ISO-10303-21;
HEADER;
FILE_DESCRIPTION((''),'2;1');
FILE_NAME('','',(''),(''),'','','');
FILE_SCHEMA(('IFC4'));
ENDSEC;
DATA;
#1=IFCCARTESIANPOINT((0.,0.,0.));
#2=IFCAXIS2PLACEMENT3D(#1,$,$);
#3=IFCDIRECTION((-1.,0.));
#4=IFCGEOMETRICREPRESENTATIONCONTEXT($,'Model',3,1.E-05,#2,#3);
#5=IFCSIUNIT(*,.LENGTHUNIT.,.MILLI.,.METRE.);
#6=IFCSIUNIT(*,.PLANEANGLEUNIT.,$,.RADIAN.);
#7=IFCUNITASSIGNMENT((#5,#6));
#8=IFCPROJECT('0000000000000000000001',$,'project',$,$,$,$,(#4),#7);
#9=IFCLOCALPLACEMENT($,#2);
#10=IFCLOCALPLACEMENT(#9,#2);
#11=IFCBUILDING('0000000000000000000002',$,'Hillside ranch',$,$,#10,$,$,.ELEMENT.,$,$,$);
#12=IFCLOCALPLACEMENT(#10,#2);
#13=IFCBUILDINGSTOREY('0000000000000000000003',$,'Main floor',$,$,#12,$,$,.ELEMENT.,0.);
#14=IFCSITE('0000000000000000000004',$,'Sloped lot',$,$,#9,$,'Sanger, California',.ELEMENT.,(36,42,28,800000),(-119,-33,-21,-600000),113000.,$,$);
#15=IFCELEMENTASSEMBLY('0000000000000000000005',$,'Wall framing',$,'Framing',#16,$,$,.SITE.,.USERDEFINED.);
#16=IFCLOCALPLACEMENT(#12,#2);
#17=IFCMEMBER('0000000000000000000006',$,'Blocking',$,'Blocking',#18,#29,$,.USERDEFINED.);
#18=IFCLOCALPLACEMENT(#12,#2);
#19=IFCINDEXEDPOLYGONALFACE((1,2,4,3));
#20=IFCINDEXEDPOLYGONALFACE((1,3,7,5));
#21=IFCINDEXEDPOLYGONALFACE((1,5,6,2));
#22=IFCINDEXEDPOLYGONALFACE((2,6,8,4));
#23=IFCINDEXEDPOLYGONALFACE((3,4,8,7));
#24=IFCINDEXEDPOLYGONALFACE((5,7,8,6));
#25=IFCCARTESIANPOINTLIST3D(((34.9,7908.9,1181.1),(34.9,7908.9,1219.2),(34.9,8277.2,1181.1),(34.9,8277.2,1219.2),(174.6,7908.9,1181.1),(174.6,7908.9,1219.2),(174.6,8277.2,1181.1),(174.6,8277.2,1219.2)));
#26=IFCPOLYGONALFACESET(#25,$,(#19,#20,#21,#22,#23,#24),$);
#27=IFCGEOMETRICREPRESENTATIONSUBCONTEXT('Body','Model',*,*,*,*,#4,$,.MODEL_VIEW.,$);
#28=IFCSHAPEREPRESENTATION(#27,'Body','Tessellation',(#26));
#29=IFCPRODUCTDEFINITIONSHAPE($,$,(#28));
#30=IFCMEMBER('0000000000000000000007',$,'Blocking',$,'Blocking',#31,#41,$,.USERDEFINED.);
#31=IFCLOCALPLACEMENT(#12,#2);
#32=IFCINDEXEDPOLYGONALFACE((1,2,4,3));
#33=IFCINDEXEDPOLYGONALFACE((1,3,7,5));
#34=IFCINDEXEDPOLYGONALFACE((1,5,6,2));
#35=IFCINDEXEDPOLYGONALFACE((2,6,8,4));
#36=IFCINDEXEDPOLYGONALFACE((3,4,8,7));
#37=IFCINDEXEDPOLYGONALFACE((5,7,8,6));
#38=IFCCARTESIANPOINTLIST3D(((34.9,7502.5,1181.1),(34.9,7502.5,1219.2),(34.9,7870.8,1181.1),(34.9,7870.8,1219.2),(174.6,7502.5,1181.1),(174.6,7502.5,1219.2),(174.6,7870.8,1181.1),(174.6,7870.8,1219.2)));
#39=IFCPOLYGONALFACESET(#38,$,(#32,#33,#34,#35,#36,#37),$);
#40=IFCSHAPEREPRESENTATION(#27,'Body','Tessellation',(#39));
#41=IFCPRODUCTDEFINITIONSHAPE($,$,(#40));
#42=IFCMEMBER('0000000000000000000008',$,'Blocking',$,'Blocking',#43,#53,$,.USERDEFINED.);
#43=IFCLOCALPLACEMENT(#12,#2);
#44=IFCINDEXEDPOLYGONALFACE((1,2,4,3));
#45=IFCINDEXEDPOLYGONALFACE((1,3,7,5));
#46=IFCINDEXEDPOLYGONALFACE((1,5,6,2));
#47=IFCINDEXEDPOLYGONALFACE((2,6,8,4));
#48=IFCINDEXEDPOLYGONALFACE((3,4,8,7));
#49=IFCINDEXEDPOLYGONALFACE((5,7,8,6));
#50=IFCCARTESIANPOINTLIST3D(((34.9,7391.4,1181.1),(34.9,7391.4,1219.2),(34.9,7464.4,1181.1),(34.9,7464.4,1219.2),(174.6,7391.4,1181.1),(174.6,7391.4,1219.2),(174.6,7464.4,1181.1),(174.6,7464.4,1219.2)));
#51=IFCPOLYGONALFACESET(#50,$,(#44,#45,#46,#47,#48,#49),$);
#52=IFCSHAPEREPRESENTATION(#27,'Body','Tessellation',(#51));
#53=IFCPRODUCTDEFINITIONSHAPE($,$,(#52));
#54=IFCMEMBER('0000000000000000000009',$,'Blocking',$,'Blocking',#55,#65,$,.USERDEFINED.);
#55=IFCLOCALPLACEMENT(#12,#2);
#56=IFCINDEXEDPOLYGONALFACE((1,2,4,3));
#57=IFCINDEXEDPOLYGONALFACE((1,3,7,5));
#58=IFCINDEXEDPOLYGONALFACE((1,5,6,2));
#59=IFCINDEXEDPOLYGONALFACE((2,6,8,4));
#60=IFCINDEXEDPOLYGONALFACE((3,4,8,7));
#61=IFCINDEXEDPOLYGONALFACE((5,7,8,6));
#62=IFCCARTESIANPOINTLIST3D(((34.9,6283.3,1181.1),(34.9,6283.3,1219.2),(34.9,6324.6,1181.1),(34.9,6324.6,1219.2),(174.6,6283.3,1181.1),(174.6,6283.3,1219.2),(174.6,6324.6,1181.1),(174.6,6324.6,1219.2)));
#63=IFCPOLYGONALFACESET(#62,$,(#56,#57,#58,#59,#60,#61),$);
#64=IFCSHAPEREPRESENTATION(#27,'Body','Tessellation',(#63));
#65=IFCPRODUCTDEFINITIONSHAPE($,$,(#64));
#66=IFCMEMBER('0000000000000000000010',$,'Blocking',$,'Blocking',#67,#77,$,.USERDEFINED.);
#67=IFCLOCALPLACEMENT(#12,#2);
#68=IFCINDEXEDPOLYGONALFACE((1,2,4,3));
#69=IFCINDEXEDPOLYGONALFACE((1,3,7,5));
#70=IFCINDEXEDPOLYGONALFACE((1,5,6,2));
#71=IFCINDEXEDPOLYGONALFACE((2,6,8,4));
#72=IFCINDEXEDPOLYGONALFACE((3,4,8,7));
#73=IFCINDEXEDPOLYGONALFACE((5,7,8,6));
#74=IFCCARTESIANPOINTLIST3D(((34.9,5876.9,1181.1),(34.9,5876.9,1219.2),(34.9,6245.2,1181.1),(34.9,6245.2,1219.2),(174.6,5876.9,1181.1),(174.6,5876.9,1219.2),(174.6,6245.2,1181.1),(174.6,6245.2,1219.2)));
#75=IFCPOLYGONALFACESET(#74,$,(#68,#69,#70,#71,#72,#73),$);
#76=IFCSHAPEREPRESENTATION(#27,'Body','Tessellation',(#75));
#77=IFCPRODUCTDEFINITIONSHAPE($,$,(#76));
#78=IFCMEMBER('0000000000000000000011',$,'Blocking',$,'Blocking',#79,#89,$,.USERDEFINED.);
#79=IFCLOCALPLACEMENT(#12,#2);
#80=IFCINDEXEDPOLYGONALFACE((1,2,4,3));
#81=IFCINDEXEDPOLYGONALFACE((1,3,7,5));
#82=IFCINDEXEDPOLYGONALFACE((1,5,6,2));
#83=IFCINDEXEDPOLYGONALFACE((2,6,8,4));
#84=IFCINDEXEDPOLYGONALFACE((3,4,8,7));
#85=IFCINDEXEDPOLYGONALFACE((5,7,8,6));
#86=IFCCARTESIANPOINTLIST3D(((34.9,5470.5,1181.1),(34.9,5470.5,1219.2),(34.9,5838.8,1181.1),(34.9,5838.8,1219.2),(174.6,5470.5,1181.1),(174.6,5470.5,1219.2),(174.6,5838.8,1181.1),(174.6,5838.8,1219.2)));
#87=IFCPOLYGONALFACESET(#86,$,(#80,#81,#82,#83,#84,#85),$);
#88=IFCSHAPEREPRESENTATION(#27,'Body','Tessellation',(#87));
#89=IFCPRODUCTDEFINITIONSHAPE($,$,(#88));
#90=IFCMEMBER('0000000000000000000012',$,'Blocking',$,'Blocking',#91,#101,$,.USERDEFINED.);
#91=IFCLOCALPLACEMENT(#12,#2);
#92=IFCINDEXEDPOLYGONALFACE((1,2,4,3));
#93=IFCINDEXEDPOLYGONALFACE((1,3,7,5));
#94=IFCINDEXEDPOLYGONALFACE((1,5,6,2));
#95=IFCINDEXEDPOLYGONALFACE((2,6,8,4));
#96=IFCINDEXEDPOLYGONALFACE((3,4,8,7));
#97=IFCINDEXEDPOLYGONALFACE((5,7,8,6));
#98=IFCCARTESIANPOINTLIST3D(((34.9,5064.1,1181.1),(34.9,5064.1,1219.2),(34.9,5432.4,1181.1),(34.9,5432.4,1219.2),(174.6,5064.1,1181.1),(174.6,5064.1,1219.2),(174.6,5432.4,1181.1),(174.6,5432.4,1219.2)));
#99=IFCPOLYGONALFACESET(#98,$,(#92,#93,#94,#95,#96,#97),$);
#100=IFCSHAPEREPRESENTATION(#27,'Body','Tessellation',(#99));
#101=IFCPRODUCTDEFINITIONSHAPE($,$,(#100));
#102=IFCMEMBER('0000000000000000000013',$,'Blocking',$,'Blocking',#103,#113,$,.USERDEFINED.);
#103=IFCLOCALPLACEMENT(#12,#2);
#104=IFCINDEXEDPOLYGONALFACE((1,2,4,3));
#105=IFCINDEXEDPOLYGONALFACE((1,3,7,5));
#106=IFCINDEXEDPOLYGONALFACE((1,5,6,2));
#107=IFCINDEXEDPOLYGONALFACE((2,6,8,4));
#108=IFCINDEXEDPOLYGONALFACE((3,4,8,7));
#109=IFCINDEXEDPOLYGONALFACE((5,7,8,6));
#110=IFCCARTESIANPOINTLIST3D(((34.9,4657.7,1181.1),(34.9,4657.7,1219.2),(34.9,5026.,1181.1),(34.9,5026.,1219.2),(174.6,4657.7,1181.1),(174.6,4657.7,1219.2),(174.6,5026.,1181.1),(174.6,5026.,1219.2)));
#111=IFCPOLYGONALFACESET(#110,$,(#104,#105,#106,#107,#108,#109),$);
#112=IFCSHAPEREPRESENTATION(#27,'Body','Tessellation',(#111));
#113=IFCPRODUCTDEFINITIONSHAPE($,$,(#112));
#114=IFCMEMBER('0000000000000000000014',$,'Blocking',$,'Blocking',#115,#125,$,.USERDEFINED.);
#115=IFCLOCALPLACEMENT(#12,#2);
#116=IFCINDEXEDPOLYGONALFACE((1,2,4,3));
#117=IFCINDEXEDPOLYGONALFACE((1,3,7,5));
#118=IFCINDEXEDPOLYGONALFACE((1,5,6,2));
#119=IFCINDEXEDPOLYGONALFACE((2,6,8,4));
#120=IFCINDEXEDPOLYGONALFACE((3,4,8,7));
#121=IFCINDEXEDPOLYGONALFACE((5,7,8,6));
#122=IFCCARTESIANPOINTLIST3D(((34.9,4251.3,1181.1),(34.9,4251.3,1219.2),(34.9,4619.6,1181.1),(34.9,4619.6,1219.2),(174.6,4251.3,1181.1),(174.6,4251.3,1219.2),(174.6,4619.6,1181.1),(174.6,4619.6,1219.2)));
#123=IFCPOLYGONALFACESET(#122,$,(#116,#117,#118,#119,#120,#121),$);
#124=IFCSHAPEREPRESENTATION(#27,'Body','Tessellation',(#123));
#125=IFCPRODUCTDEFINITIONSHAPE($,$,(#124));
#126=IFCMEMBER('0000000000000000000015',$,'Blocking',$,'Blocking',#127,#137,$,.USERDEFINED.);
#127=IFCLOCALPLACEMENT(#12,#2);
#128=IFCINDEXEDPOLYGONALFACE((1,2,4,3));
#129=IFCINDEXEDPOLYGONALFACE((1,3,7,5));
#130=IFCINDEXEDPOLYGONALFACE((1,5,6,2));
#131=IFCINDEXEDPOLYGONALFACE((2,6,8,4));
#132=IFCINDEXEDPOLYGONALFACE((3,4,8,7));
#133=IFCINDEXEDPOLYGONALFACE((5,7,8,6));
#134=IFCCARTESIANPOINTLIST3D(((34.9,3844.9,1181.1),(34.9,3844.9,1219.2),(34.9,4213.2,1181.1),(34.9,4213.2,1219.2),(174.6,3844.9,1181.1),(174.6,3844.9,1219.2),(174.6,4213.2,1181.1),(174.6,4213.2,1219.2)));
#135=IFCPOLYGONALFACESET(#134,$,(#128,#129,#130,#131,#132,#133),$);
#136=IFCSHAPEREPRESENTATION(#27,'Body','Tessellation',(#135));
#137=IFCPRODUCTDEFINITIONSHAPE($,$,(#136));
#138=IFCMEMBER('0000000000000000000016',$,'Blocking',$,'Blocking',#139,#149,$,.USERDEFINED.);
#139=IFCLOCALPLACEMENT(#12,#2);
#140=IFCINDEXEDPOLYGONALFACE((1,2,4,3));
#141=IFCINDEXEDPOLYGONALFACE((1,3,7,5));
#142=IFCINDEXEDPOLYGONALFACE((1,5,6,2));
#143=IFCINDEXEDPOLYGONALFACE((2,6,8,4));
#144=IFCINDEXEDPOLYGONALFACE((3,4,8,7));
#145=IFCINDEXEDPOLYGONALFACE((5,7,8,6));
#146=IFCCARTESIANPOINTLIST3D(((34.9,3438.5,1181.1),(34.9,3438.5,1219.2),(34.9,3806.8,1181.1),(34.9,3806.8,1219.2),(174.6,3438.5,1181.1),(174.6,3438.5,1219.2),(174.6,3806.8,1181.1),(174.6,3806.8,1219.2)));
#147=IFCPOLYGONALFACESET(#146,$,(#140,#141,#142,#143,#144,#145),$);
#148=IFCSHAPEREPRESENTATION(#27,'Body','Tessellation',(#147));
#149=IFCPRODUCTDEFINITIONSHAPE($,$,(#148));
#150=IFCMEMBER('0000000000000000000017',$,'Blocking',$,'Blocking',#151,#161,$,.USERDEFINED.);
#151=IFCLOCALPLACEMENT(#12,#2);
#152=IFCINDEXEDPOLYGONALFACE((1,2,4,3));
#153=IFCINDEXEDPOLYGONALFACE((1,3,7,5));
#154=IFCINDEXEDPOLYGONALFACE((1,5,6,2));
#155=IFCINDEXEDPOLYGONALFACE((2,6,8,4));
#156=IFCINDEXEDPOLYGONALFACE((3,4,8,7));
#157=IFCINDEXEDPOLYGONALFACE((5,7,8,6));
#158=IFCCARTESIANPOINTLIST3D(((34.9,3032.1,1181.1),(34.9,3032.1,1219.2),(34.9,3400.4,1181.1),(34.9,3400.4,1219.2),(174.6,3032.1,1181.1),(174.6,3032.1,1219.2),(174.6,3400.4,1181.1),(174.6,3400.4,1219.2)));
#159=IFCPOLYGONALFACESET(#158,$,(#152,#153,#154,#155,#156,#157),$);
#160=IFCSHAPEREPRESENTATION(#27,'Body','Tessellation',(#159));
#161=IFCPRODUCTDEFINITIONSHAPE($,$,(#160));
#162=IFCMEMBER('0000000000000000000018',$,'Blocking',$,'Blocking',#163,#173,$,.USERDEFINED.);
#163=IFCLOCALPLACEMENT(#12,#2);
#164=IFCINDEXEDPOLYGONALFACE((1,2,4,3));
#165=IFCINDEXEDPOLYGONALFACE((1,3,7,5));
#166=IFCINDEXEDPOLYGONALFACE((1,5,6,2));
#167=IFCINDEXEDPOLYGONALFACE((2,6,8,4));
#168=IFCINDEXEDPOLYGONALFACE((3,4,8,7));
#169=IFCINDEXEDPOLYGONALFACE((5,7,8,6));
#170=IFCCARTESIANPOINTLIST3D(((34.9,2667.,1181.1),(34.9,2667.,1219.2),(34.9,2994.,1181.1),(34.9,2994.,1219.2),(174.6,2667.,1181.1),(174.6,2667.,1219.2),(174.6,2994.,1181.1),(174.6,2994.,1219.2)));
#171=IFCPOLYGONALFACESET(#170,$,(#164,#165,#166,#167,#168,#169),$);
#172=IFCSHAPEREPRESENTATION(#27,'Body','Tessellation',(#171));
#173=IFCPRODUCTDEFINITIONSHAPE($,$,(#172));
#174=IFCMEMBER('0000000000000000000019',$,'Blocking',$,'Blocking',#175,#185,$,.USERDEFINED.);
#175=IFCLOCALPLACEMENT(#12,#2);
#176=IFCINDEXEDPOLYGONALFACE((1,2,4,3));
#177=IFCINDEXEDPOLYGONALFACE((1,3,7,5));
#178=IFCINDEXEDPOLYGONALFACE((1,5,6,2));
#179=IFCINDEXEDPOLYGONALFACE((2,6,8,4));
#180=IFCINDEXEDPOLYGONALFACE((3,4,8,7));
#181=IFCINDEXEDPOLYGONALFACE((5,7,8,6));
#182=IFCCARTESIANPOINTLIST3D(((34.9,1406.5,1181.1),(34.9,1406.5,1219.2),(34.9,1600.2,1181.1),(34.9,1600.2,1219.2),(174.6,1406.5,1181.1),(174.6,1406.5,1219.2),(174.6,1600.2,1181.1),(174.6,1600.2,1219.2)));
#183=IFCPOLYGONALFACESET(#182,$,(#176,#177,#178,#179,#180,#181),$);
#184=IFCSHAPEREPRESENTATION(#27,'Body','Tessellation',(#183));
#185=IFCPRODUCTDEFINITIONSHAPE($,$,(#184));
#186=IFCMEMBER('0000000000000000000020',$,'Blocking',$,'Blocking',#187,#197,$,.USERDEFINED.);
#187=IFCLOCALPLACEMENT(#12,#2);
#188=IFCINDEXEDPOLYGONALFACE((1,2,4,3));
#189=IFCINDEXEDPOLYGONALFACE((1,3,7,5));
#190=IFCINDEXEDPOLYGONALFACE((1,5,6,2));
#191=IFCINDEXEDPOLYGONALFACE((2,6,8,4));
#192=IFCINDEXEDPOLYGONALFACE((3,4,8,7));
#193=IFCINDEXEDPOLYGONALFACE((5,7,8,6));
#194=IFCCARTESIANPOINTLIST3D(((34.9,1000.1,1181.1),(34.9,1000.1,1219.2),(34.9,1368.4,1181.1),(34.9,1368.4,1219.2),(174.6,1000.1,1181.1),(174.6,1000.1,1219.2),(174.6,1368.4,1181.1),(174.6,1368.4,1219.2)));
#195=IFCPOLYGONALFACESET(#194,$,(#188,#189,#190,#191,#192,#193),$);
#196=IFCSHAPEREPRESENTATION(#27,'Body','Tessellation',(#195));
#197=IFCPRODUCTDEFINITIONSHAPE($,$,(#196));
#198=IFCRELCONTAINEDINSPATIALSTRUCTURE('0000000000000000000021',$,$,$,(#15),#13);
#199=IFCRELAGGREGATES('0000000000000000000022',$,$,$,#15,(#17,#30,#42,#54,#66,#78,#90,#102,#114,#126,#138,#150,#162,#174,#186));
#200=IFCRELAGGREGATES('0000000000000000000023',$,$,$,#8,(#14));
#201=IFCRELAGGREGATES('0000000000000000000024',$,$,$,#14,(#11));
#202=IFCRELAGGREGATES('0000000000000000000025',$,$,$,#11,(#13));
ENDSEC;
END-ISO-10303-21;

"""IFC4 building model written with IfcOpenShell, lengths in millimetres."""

from ifc_helpers import new_model, si_unit, direction, frame, origin, origin_with_axes, place, context, subcontext, project, spatial, polyline, outline, extrude, element, aggregate, save


model = new_model("IFC4")

# Units and contexts
model_context = context("Model", 3, precision=1e-05, world=origin(), true_north=direction((-1.0, 0.0)))
body_context = subcontext(model_context, "Body", "Model", "MODEL_VIEW")
ifc_project = project(units=[si_unit("LENGTHUNIT", "METRE", prefix="MILLI"), si_unit("PLANEANGLEUNIT", "RADIAN")], contexts=[model_context])

# Site, building, storey
site_placement = place(None, origin())
site = spatial("IfcSite", under=ifc_project, at=site_placement, Name="Sloped lot", LongName="Sanger, California", CompositionType="ELEMENT", RefLatitude=(36, 42, 28, 800000), RefLongitude=(-119, -33, -21, -600000), RefElevation=113000.0)
building_placement = place(site_placement, origin())
building = spatial("IfcBuilding", under=site, at=building_placement, Name="Hillside ranch", CompositionType="ELEMENT")
storey_placement = place(building_placement, origin())
storey = spatial("IfcBuildingStorey", under=building, at=storey_placement, Name="Main floor", CompositionType="ELEMENT", Elevation=0.0)

# Element assembly, members
assembly_1_placement = place(storey_placement, origin_with_axes())
assembly_1 = element("IfcElementAssembly", 1, at=assembly_1_placement, inside=storey, Name="Wall framing", ObjectType="Framing", AssemblyPlace="SITE", PredefinedType="USERDEFINED")
member_1_placement = place(storey_placement, origin_with_axes())
member_1 = element("IfcMember", 2, at=member_1_placement, Name="Blocking", ObjectType="Blocking", PredefinedType="USERDEFINED", context=body_context, shape_type="SweptSolid", body=[
    extrude(outline(polyline([(0.0, 0.0), (368.3, 0.0), (368.3, 139.7), (0.0, 139.7), (0.0, 0.0)])), frame((34.9, 8277.2, 1181.1), z_axis=(0.0, 0.0, 1.0), x_axis=(0.0, -1.0, 0.0)), (0.0, 0.0, 1.0), 38.1),
])
member_2_placement = place(storey_placement, origin_with_axes())
member_2 = element("IfcMember", 3, at=member_2_placement, Name="Blocking", ObjectType="Blocking", PredefinedType="USERDEFINED", context=body_context, shape_type="SweptSolid", body=[
    extrude(outline(polyline([(0.0, 0.0), (368.3, 0.0), (368.3, 139.7), (0.0, 139.7), (0.0, 0.0)])), frame((34.9, 7870.8, 1181.1), z_axis=(0.0, 0.0, 1.0), x_axis=(0.0, -1.0, 0.0)), (0.0, 0.0, 1.0), 38.1),
])
member_3_placement = place(storey_placement, origin_with_axes())
member_3 = element("IfcMember", 4, at=member_3_placement, Name="Blocking", ObjectType="Blocking", PredefinedType="USERDEFINED", context=body_context, shape_type="SweptSolid", body=[
    extrude(outline(polyline([(0.0, 0.0), (73.0, 0.0), (73.0, 139.7), (0.0, 139.7), (0.0, 0.0)])), frame((34.9, 7464.4, 1181.1), z_axis=(0.0, 0.0, 1.0), x_axis=(0.0, -1.0, 0.0)), (0.0, 0.0, 1.0), 38.1),
])
member_4_placement = place(storey_placement, origin_with_axes())
member_4 = element("IfcMember", 5, at=member_4_placement, Name="Blocking", ObjectType="Blocking", PredefinedType="USERDEFINED", context=body_context, shape_type="SweptSolid", body=[
    extrude(outline(polyline([(0.0, 0.0), (41.3, 0.0), (41.3, 139.7), (0.0, 139.7), (0.0, 0.0)])), frame((34.9, 6324.6, 1181.1), z_axis=(0.0, 0.0, 1.0), x_axis=(0.0, -1.0, 0.0)), (0.0, 0.0, 1.0), 38.1),
])
member_5_placement = place(storey_placement, origin_with_axes())
member_5 = element("IfcMember", 6, at=member_5_placement, Name="Blocking", ObjectType="Blocking", PredefinedType="USERDEFINED", context=body_context, shape_type="SweptSolid", body=[
    extrude(outline(polyline([(0.0, 0.0), (368.3, 0.0), (368.3, 139.7), (0.0, 139.7), (0.0, 0.0)])), frame((34.9, 6245.2, 1181.1), z_axis=(0.0, 0.0, 1.0), x_axis=(0.0, -1.0, 0.0)), (0.0, 0.0, 1.0), 38.1),
])
member_6_placement = place(storey_placement, origin_with_axes())
member_6 = element("IfcMember", 7, at=member_6_placement, Name="Blocking", ObjectType="Blocking", PredefinedType="USERDEFINED", context=body_context, shape_type="SweptSolid", body=[
    extrude(outline(polyline([(0.0, 0.0), (368.3, 0.0), (368.3, 139.7), (0.0, 139.7), (0.0, 0.0)])), frame((34.9, 5838.8, 1181.1), z_axis=(0.0, 0.0, 1.0), x_axis=(0.0, -1.0, 0.0)), (0.0, 0.0, 1.0), 38.1),
])
member_7_placement = place(storey_placement, origin_with_axes())
member_7 = element("IfcMember", 8, at=member_7_placement, Name="Blocking", ObjectType="Blocking", PredefinedType="USERDEFINED", context=body_context, shape_type="SweptSolid", body=[
    extrude(outline(polyline([(0.0, 0.0), (368.3, 0.0), (368.3, 139.7), (0.0, 139.7), (0.0, 0.0)])), frame((34.9, 5432.4, 1181.1), z_axis=(0.0, 0.0, 1.0), x_axis=(0.0, -1.0, 0.0)), (0.0, 0.0, 1.0), 38.1),
])
member_8_placement = place(storey_placement, origin_with_axes())
member_8 = element("IfcMember", 9, at=member_8_placement, Name="Blocking", ObjectType="Blocking", PredefinedType="USERDEFINED", context=body_context, shape_type="SweptSolid", body=[
    extrude(outline(polyline([(0.0, 0.0), (368.3, 0.0), (368.3, 139.7), (0.0, 139.7), (0.0, 0.0)])), frame((34.9, 5026.0, 1181.1), z_axis=(0.0, 0.0, 1.0), x_axis=(0.0, -1.0, 0.0)), (0.0, 0.0, 1.0), 38.1),
])
member_9_placement = place(storey_placement, origin_with_axes())
member_9 = element("IfcMember", 10, at=member_9_placement, Name="Blocking", ObjectType="Blocking", PredefinedType="USERDEFINED", context=body_context, shape_type="SweptSolid", body=[
    extrude(outline(polyline([(0.0, 0.0), (368.3, 0.0), (368.3, 139.7), (0.0, 139.7), (0.0, 0.0)])), frame((34.9, 4619.6, 1181.1), z_axis=(0.0, 0.0, 1.0), x_axis=(0.0, -1.0, 0.0)), (0.0, 0.0, 1.0), 38.1),
])
member_10_placement = place(storey_placement, origin_with_axes())
member_10 = element("IfcMember", 11, at=member_10_placement, Name="Blocking", ObjectType="Blocking", PredefinedType="USERDEFINED", context=body_context, shape_type="SweptSolid", body=[
    extrude(outline(polyline([(0.0, 0.0), (368.3, 0.0), (368.3, 139.7), (0.0, 139.7), (0.0, 0.0)])), frame((34.9, 4213.2, 1181.1), z_axis=(0.0, 0.0, 1.0), x_axis=(0.0, -1.0, 0.0)), (0.0, 0.0, 1.0), 38.1),
])
member_11_placement = place(storey_placement, origin_with_axes())
member_11 = element("IfcMember", 12, at=member_11_placement, Name="Blocking", ObjectType="Blocking", PredefinedType="USERDEFINED", context=body_context, shape_type="SweptSolid", body=[
    extrude(outline(polyline([(0.0, 0.0), (368.3, 0.0), (368.3, 139.7), (0.0, 139.7), (0.0, 0.0)])), frame((34.9, 3806.8, 1181.1), z_axis=(0.0, 0.0, 1.0), x_axis=(0.0, -1.0, 0.0)), (0.0, 0.0, 1.0), 38.1),
])
member_12_placement = place(storey_placement, origin_with_axes())
member_12 = element("IfcMember", 13, at=member_12_placement, Name="Blocking", ObjectType="Blocking", PredefinedType="USERDEFINED", context=body_context, shape_type="SweptSolid", body=[
    extrude(outline(polyline([(0.0, 0.0), (368.3, 0.0), (368.3, 139.7), (0.0, 139.7), (0.0, 0.0)])), frame((34.9, 3400.4, 1181.1), z_axis=(0.0, 0.0, 1.0), x_axis=(0.0, -1.0, 0.0)), (0.0, 0.0, 1.0), 38.1),
])
member_13_placement = place(storey_placement, origin_with_axes())
member_13 = element("IfcMember", 14, at=member_13_placement, Name="Blocking", ObjectType="Blocking", PredefinedType="USERDEFINED", context=body_context, shape_type="SweptSolid", body=[
    extrude(outline(polyline([(0.0, 0.0), (327.0, 0.0), (327.0, 139.7), (0.0, 139.7), (0.0, 0.0)])), frame((34.9, 2994.0, 1181.1), z_axis=(0.0, 0.0, 1.0), x_axis=(0.0, -1.0, 0.0)), (0.0, 0.0, 1.0), 38.1),
])
member_14_placement = place(storey_placement, origin_with_axes())
member_14 = element("IfcMember", 15, at=member_14_placement, Name="Blocking", ObjectType="Blocking", PredefinedType="USERDEFINED", context=body_context, shape_type="SweptSolid", body=[
    extrude(outline(polyline([(0.0, 0.0), (193.7, 0.0), (193.7, 139.7), (0.0, 139.7), (0.0, 0.0)])), frame((34.9, 1600.2, 1181.1), z_axis=(0.0, 0.0, 1.0), x_axis=(0.0, -1.0, 0.0)), (0.0, 0.0, 1.0), 38.1),
])
member_15_placement = place(storey_placement, origin_with_axes())
member_15 = element("IfcMember", 16, at=member_15_placement, Name="Blocking", ObjectType="Blocking", PredefinedType="USERDEFINED", context=body_context, shape_type="SweptSolid", body=[
    extrude(outline(polyline([(0.0, 0.0), (368.3, 0.0), (368.3, 139.7), (0.0, 139.7), (0.0, 0.0)])), frame((34.9, 1368.4, 1181.1), z_axis=(0.0, 0.0, 1.0), x_axis=(0.0, -1.0, 0.0)), (0.0, 0.0, 1.0), 38.1),
])
aggregate(assembly_1, [member_1, member_2, member_3, member_4, member_5, member_6, member_7, member_8, member_9, member_10, member_11, member_12, member_13, member_14, member_15])

save(model, "model.ifc")
